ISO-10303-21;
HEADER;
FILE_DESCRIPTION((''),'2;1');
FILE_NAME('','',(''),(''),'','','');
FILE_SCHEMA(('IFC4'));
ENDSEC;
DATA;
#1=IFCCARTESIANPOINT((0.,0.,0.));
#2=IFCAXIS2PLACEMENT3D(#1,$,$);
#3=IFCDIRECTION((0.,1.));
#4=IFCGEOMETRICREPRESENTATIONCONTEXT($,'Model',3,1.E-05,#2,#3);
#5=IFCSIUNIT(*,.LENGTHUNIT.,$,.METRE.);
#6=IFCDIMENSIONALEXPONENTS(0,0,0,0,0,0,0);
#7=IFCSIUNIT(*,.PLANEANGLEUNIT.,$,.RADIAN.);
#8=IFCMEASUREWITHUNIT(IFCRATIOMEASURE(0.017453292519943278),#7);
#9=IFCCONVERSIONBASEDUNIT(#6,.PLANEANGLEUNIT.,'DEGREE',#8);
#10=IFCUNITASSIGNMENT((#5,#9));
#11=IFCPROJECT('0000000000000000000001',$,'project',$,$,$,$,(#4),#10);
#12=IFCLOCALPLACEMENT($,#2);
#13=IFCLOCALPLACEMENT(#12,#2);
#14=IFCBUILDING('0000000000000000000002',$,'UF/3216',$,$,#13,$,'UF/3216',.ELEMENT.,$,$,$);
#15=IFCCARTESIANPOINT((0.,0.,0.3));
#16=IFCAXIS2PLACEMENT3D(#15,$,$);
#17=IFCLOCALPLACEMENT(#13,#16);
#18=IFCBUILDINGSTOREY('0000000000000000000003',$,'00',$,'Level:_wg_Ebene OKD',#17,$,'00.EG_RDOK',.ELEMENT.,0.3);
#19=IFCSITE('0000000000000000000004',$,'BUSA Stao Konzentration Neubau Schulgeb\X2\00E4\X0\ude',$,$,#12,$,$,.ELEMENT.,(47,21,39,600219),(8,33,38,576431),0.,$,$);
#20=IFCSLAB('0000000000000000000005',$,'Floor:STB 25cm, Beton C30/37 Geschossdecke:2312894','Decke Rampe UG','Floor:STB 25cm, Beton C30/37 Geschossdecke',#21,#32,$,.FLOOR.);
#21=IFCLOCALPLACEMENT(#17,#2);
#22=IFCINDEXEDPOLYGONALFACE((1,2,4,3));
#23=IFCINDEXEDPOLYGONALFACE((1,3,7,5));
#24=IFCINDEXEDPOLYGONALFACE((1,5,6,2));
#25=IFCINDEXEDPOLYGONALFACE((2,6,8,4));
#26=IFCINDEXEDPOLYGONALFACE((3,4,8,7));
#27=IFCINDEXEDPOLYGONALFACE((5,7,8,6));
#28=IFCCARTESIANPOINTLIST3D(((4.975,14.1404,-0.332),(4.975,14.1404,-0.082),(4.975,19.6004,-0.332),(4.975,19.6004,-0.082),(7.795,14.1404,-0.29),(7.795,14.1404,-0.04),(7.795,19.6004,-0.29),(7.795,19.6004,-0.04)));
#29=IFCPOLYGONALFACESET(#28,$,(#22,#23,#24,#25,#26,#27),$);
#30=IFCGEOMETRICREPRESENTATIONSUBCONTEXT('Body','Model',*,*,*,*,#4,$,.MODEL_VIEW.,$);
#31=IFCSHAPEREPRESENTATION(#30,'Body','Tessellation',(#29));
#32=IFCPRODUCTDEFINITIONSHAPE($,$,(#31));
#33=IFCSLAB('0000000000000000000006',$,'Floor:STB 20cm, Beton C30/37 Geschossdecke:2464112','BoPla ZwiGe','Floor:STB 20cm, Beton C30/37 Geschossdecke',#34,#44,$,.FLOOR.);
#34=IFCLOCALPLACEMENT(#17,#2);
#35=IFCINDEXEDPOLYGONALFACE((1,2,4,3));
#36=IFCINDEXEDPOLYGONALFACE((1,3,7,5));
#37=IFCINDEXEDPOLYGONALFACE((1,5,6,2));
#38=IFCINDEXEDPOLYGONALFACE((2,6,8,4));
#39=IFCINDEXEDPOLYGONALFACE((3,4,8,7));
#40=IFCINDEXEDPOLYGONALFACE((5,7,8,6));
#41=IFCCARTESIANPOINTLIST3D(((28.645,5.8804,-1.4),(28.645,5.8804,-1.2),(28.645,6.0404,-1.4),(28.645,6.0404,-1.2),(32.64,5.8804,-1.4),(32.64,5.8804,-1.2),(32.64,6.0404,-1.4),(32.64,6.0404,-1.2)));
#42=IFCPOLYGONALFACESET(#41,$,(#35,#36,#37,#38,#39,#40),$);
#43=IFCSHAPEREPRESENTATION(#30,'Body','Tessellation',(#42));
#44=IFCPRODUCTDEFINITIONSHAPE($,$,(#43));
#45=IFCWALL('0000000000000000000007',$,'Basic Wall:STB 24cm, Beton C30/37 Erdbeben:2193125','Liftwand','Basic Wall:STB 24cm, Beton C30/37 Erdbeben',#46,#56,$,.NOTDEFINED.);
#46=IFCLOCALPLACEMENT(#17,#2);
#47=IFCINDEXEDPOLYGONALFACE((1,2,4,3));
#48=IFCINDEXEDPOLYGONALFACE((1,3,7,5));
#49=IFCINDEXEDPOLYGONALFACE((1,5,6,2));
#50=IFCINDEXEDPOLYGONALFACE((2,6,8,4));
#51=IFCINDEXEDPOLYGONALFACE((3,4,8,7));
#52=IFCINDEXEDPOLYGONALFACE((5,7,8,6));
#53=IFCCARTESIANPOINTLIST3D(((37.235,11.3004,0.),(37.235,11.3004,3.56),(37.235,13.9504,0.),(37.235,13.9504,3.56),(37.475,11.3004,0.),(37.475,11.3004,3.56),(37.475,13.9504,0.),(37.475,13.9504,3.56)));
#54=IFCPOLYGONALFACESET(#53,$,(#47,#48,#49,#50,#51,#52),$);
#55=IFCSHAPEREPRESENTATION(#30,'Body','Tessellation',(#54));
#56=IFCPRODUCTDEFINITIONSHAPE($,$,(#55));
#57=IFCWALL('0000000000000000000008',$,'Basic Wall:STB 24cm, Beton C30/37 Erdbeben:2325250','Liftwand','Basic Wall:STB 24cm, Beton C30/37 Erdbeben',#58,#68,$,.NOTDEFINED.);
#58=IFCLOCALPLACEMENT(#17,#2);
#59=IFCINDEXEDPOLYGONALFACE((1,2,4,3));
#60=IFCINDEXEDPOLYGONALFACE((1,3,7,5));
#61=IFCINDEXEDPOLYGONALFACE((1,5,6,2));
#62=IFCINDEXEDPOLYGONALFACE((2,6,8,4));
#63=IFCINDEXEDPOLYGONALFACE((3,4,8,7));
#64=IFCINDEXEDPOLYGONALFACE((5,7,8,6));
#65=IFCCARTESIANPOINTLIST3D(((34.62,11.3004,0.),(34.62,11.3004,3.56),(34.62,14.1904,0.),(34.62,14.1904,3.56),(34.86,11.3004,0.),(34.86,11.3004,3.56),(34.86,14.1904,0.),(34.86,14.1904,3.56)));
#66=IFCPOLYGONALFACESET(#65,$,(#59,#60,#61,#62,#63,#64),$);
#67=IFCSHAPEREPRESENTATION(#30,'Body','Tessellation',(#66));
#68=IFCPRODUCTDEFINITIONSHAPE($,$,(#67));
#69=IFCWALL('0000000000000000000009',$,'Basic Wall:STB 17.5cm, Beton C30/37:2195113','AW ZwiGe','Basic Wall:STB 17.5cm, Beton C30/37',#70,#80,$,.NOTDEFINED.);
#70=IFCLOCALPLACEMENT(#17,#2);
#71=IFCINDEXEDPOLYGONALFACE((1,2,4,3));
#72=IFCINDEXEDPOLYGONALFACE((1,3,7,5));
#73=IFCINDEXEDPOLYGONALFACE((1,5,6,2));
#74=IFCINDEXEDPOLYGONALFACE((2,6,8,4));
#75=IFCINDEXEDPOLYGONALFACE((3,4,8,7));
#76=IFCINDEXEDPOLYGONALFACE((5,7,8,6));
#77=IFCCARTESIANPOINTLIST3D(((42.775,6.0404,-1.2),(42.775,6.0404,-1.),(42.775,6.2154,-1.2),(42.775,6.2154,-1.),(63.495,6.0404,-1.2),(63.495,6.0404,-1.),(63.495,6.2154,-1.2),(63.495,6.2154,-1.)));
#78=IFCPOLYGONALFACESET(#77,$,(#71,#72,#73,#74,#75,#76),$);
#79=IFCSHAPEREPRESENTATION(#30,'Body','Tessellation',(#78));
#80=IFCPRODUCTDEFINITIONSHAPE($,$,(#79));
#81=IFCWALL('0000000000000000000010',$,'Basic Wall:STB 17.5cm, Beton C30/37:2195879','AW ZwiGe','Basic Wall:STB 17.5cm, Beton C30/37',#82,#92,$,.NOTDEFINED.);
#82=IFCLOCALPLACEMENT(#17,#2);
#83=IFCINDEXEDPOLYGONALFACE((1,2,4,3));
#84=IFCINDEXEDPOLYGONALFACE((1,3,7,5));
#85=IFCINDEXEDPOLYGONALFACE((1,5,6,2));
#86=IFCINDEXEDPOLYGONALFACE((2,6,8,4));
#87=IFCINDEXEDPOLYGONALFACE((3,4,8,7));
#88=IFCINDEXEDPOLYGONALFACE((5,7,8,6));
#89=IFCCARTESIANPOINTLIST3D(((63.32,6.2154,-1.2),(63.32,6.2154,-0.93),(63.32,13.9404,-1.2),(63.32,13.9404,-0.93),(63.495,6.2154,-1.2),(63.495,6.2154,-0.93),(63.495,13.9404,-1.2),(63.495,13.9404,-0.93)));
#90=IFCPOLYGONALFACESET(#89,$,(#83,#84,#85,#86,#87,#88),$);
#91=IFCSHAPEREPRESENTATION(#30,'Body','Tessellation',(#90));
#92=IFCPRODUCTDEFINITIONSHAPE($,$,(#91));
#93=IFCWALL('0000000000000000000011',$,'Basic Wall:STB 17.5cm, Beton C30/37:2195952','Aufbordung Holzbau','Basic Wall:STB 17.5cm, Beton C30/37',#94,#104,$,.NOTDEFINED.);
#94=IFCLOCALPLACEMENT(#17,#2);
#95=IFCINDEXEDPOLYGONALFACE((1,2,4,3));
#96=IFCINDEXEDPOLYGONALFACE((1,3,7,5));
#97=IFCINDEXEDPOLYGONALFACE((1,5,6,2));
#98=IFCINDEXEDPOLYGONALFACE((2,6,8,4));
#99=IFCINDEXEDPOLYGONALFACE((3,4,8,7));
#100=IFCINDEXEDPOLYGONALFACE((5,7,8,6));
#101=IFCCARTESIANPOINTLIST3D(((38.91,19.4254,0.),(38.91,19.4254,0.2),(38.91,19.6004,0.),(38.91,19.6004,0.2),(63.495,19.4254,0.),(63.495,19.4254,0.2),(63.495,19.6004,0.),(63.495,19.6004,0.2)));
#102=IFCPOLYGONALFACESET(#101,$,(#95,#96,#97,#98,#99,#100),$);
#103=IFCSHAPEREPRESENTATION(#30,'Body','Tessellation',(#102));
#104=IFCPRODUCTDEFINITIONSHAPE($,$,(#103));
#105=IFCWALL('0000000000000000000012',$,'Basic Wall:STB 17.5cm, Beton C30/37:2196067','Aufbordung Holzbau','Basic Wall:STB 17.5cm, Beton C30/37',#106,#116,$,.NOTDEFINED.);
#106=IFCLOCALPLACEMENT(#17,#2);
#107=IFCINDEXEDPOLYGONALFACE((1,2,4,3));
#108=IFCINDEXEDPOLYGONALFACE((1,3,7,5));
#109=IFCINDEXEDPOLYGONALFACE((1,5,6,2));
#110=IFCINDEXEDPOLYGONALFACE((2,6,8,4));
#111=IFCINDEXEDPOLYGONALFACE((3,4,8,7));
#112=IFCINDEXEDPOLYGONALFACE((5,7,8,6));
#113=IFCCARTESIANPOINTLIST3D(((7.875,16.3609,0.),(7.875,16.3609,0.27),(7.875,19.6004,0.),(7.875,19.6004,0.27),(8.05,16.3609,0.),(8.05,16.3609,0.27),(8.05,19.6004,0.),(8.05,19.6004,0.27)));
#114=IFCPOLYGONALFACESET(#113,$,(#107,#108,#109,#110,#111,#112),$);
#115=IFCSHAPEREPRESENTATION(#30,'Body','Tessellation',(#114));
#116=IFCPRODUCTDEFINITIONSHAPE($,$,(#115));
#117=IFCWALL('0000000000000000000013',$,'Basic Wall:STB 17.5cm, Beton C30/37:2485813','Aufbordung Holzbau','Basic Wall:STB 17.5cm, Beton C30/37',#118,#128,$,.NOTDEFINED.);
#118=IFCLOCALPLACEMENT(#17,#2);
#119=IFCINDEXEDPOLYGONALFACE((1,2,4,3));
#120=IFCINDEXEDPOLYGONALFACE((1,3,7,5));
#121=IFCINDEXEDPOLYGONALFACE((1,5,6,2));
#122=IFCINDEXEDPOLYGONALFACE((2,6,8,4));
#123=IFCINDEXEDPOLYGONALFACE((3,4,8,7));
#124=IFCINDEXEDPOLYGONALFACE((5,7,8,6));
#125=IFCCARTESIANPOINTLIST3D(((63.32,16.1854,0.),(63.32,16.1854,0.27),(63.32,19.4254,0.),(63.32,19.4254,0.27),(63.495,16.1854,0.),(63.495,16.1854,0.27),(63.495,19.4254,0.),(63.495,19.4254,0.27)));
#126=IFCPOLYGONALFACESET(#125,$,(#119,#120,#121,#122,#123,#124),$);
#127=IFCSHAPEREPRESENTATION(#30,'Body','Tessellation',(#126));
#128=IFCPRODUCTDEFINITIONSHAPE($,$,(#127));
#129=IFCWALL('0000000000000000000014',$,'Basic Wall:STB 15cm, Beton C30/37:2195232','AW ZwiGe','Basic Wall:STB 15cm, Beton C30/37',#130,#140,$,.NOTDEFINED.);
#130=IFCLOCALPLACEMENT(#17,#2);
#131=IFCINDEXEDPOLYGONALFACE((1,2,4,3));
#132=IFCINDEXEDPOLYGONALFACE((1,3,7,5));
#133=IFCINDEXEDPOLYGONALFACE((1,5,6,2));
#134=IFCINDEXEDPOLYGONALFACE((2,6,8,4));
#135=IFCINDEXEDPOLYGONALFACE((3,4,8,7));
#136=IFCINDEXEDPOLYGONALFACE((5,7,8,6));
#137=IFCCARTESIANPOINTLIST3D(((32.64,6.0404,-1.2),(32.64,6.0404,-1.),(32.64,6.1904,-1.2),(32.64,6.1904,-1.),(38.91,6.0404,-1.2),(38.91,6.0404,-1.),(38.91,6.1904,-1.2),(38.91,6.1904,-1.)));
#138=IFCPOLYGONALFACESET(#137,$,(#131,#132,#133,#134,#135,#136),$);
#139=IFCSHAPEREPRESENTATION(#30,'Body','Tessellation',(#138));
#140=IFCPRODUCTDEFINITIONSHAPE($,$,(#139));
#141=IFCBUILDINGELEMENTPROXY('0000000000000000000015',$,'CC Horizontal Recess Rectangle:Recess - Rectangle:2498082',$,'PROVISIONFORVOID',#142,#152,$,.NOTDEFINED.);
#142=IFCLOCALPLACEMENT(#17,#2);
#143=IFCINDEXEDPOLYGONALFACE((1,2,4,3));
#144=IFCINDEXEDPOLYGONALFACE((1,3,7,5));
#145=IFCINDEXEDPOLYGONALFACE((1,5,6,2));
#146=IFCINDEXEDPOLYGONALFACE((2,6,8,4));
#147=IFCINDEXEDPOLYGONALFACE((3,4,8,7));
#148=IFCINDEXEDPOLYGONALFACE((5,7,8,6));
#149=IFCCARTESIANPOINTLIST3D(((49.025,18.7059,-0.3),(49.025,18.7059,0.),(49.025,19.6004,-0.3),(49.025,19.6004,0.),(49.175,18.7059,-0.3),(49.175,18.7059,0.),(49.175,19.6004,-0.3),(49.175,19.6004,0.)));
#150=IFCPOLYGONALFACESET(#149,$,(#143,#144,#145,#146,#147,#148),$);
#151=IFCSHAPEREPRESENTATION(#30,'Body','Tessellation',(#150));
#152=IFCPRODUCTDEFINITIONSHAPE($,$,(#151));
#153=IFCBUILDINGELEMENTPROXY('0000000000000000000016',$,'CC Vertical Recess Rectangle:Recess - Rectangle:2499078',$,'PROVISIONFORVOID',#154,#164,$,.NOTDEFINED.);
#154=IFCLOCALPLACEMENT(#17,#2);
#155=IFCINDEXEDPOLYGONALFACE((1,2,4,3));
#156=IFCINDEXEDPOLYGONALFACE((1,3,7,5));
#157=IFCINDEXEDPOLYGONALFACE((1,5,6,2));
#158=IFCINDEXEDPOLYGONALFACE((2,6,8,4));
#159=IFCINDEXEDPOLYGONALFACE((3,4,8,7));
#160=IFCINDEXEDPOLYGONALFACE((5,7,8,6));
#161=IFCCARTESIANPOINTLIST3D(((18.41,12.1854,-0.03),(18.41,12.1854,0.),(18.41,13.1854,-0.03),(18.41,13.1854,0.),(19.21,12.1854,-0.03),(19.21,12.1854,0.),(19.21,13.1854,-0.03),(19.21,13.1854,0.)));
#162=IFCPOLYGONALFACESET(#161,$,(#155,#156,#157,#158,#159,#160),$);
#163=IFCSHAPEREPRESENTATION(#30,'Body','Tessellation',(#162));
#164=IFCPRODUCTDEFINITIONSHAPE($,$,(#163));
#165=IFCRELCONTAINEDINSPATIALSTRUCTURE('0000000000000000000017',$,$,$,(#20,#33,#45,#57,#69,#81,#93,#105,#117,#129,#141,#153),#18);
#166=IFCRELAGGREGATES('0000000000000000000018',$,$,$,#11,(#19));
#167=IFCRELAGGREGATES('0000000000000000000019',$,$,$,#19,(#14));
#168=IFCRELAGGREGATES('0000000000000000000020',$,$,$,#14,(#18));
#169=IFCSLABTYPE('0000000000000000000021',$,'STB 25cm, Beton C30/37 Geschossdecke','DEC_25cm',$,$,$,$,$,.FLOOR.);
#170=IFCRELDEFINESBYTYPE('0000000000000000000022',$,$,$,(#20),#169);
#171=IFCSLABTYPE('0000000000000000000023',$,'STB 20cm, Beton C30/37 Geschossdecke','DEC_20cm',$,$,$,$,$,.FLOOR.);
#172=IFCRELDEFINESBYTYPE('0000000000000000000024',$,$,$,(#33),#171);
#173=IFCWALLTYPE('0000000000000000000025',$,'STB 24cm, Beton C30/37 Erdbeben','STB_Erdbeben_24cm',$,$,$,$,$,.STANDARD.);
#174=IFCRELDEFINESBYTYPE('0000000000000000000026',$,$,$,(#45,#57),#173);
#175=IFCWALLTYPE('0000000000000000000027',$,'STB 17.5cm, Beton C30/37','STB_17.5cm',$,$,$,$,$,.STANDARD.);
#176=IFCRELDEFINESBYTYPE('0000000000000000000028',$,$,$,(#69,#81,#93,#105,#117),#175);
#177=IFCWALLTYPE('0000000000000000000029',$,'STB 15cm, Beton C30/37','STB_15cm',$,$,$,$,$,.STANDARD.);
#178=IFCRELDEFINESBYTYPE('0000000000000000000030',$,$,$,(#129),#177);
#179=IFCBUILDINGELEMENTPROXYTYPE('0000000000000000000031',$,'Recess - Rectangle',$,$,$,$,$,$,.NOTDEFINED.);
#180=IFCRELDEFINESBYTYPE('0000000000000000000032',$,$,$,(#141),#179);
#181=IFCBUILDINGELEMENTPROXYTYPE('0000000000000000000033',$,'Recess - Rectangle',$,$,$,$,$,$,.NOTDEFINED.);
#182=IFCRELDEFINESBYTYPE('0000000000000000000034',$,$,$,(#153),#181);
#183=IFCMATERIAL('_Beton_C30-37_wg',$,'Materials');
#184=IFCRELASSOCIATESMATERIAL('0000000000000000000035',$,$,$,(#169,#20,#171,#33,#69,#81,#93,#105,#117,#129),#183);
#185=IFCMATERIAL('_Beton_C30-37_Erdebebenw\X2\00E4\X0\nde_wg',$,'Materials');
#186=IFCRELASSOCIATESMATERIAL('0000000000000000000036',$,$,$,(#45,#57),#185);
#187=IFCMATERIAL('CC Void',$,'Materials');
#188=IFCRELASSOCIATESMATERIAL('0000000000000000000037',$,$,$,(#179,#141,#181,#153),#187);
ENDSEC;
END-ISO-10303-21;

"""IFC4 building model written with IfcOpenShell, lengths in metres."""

from ifc_helpers import new_model, entity, si_unit, converted_unit, direction, frame, frame_2d, origin, place, context, subcontext, project, spatial, indexed_curve, rectangle, outline, extrude, source, transform, mapped, material, type_object, type_shapes, element, save


model = new_model("IFC4")

# Units and contexts
model_context = context("Model", 3, precision=1e-05, world=origin(), true_north=direction((0.0, 1.0)))
body_context = subcontext(model_context, "Body", "Model", "MODEL_VIEW")
ifc_project = project(units=[si_unit("LENGTHUNIT", "METRE"), converted_unit("PLANEANGLEUNIT", "DEGREE", entity("IfcRatioMeasure", 0.017453292519943278), si_unit("PLANEANGLEUNIT", "RADIAN"), dimensions=[0, 0, 0, 0, 0, 0, 0])], contexts=[model_context])

# Site, building, storey
site_placement = place(None, origin())
site = spatial("IfcSite", under=ifc_project, at=site_placement, Name="BUSA Stao Konzentration Neubau Schulgebäude", CompositionType="ELEMENT", RefLatitude=(47, 21, 39, 600219), RefLongitude=(8, 33, 38, 576431), RefElevation=0.0)
building_placement = place(site_placement, origin())
building = spatial("IfcBuilding", under=site, at=building_placement, Name="UF/3216", LongName="UF/3216", CompositionType="ELEMENT")
storey_placement = place(building_placement, frame((0.0, 0.0, 0.3)))
storey = spatial("IfcBuildingStorey", under=building, at=storey_placement, Name="00", ObjectType="Level:_wg_Ebene OKD", LongName="00.EG_RDOK", CompositionType="ELEMENT", Elevation=0.3)

# Slabs
ifc_material_1 = material(Name="_Beton_C30-37_wg", Category="Materials")
slab_type_1 = type_object("IfcSlabType", Name="STB 25cm, Beton C30/37 Geschossdecke", Description="DEC_25cm", PredefinedType="FLOOR", material=ifc_material_1)
slab_1_placement = place(storey_placement, frame((4.975, 14.1404, -0.332)))
element("IfcSlab", 1, at=slab_1_placement, inside=storey, type_object=slab_type_1, material=ifc_material_1, Name="Floor:STB 25cm, Beton C30/37 Geschossdecke:2312894", Description="Decke Rampe UG", ObjectType="Floor:STB 25cm, Beton C30/37 Geschossdecke", PredefinedType="FLOOR", context=body_context, shape_type="SweptSolid", body=[
    extrude(rectangle(XDim=5.46, YDim=2.8203, at=frame_2d((-1.4102, 0.0), x_axis=(0.0, -1.0))), frame((2.82, 2.73, 0.292), z_axis=(-0.014892, 0.0, 0.999889), x_axis=(0.999889, 0.0, 0.014892)), (-0.014892, 0.0, -0.999889), 0.25),
])
slab_type_2 = type_object("IfcSlabType", Name="STB 20cm, Beton C30/37 Geschossdecke", Description="DEC_20cm", PredefinedType="FLOOR", material=ifc_material_1)
slab_2_placement = place(storey_placement, frame((28.645, 5.8804, -1.4)))
element("IfcSlab", 2, at=slab_2_placement, inside=storey, type_object=slab_type_2, material=ifc_material_1, Name="Floor:STB 20cm, Beton C30/37 Geschossdecke:2464112", Description="BoPla ZwiGe", ObjectType="Floor:STB 20cm, Beton C30/37 Geschossdecke", PredefinedType="FLOOR", context=body_context, shape_type="SweptSolid", body=[
    extrude(rectangle(XDim=3.995, YDim=0.16, at=frame_2d((5.0675, 0.0), x_axis=(-1.0, 0.0))), frame((7.065, 0.08, 0.2), z_axis=(0.0, 0.0, -1.0), x_axis=(-1.0, 0.0, 0.0)), (0.0, 0.0, 1.0), 0.2),
])

# Walls
ifc_material_2 = material(Name="_Beton_C30-37_Erdebebenwände_wg", Category="Materials")
wall_type_1 = type_object("IfcWallType", Name="STB 24cm, Beton C30/37 Erdbeben", Description="STB_Erdbeben_24cm", PredefinedType="STANDARD")
wall_1_placement = place(storey_placement, frame((37.355, 13.9504, 0.0), z_axis=(0.0, 0.0, 1.0), x_axis=(0.0, -1.0, 0.0)))
element("IfcWall", 3, at=wall_1_placement, inside=storey, type_object=wall_type_1, material=ifc_material_2, Name="Basic Wall:STB 24cm, Beton C30/37 Erdbeben:2193125", Description="Liftwand", ObjectType="Basic Wall:STB 24cm, Beton C30/37 Erdbeben", PredefinedType="NOTDEFINED", context=body_context, shape_type="SweptSolid", body=[
    extrude(outline(indexed_curve([(2.65, 0.12), (0.0, 0.12), (0.0, -0.12), (2.65, -0.12), (2.65, 0.12)], self_intersect=False)), origin(), (0.0, 0.0, 1.0), 3.56),
])
wall_2_placement = place(storey_placement, frame((34.74, 11.3004, 0.0), z_axis=(0.0, 0.0, 1.0), x_axis=(0.0, 1.0, 0.0)))
element("IfcWall", 4, at=wall_2_placement, inside=storey, type_object=wall_type_1, material=ifc_material_2, Name="Basic Wall:STB 24cm, Beton C30/37 Erdbeben:2325250", Description="Liftwand", ObjectType="Basic Wall:STB 24cm, Beton C30/37 Erdbeben", PredefinedType="NOTDEFINED", context=body_context, shape_type="SweptSolid", body=[
    extrude(outline(indexed_curve([(2.89, 0.12), (0.0, 0.12), (0.0, -0.12), (2.89, -0.12), (2.89, 0.12)], self_intersect=False)), origin(), (0.0, 0.0, 1.0), 3.56),
])
wall_type_2 = type_object("IfcWallType", Name="STB 17.5cm, Beton C30/37", Description="STB_17.5cm", PredefinedType="STANDARD")
wall_3_placement = place(storey_placement, frame((63.495, 6.1279, -1.2), z_axis=(0.0, 0.0, 1.0), x_axis=(-1.0, 0.0, 0.0)))
element("IfcWall", 5, at=wall_3_placement, inside=storey, type_object=wall_type_2, material=ifc_material_1, Name="Basic Wall:STB 17.5cm, Beton C30/37:2195113", Description="AW ZwiGe", ObjectType="Basic Wall:STB 17.5cm, Beton C30/37", PredefinedType="NOTDEFINED", context=body_context, shape_type="SweptSolid", body=[
    extrude(outline(indexed_curve([(20.72, 0.0875), (0.0, 0.0875), (0.0, -0.0875), (20.72, -0.0875), (20.72, 0.0875)], self_intersect=False)), origin(), (0.0, 0.0, 1.0), 0.2),
])
wall_4_placement = place(storey_placement, frame((63.4075, 6.2154, -1.2), z_axis=(0.0, 0.0, 1.0), x_axis=(0.0, 1.0, 0.0)))
element("IfcWall", 6, at=wall_4_placement, inside=storey, type_object=wall_type_2, material=ifc_material_1, Name="Basic Wall:STB 17.5cm, Beton C30/37:2195879", Description="AW ZwiGe", ObjectType="Basic Wall:STB 17.5cm, Beton C30/37", PredefinedType="NOTDEFINED", context=body_context, shape_type="SweptSolid", body=[
    extrude(outline(indexed_curve([(7.725, 0.0875), (0.0, 0.0875), (0.0, -0.0875), (7.725, -0.0875), (7.725, 0.0875)], self_intersect=False)), origin(), (0.0, 0.0, 1.0), 0.27),
])
wall_5_placement = place(storey_placement, frame((63.495, 19.5129, 0.0), z_axis=(0.0, 0.0, 1.0), x_axis=(-1.0, 0.0, 0.0)))
element("IfcWall", 7, at=wall_5_placement, inside=storey, type_object=wall_type_2, material=ifc_material_1, Name="Basic Wall:STB 17.5cm, Beton C30/37:2195952", Description="Aufbordung Holzbau", ObjectType="Basic Wall:STB 17.5cm, Beton C30/37", PredefinedType="NOTDEFINED", context=body_context, shape_type="SweptSolid", body=[
    extrude(outline(indexed_curve([(24.585, 0.0875), (0.0, 0.0875), (0.0, -0.0875), (24.585, -0.0875), (24.585, 0.0875)], self_intersect=False)), origin(), (0.0, 0.0, 1.0), 0.2),
])
wall_6_placement = place(storey_placement, frame((7.9625, 19.6004, 0.0), z_axis=(0.0, 0.0, 1.0), x_axis=(0.0, -1.0, 0.0)))
element("IfcWall", 8, at=wall_6_placement, inside=storey, type_object=wall_type_2, material=ifc_material_1, Name="Basic Wall:STB 17.5cm, Beton C30/37:2196067", Description="Aufbordung Holzbau", ObjectType="Basic Wall:STB 17.5cm, Beton C30/37", PredefinedType="NOTDEFINED", context=body_context, shape_type="SweptSolid", body=[
    extrude(outline(indexed_curve([(3.2395, 0.0875), (0.0, 0.0875), (0.0, -0.0875), (3.2395, -0.0875), (3.2395, 0.0875)], self_intersect=False)), origin(), (0.0, 0.0, 1.0), 0.27),
])
wall_7_placement = place(storey_placement, frame((63.4075, 19.4254, 0.0), z_axis=(0.0, 0.0, 1.0), x_axis=(0.0, -1.0, 0.0)))
element("IfcWall", 9, at=wall_7_placement, inside=storey, type_object=wall_type_2, material=ifc_material_1, Name="Basic Wall:STB 17.5cm, Beton C30/37:2485813", Description="Aufbordung Holzbau", ObjectType="Basic Wall:STB 17.5cm, Beton C30/37", PredefinedType="NOTDEFINED", context=body_context, shape_type="SweptSolid", body=[
    extrude(outline(indexed_curve([(3.24, 0.0875), (0.0, 0.0875), (0.0, -0.0875), (3.24, -0.0875), (3.24, 0.0875)], self_intersect=False)), origin(), (0.0, 0.0, 1.0), 0.27),
])
wall_type_3 = type_object("IfcWallType", Name="STB 15cm, Beton C30/37", Description="STB_15cm", PredefinedType="STANDARD")
wall_8_placement = place(storey_placement, frame((38.91, 6.1154, -1.2), z_axis=(0.0, 0.0, 1.0), x_axis=(-1.0, 0.0, 0.0)))
element("IfcWall", 10, at=wall_8_placement, inside=storey, type_object=wall_type_3, material=ifc_material_1, Name="Basic Wall:STB 15cm, Beton C30/37:2195232", Description="AW ZwiGe", ObjectType="Basic Wall:STB 15cm, Beton C30/37", PredefinedType="NOTDEFINED", context=body_context, shape_type="SweptSolid", body=[
    extrude(outline(indexed_curve([(6.27, 0.075), (0.0, 0.075), (0.0, -0.075), (6.27, -0.075), (6.27, 0.075)], self_intersect=False)), origin(), (0.0, 0.0, 1.0), 0.2),
])

# Building element proxies
ifc_material_3 = material(Name="CC Void", Category="Materials")
building_element_proxy_type_1 = type_object("IfcBuildingElementProxyType", Name="Recess - Rectangle", PredefinedType="NOTDEFINED", material=ifc_material_3)
shared_shape_1 = source(origin(), body_context, "Body", "SweptSolid", [
    extrude(outline(indexed_curve([(-0.4472, -0.075), (0.4472, -0.075), (0.4472, 0.075), (-0.4472, 0.075), (-0.4472, -0.075)], self_intersect=False)), frame((0.0, 0.0, 0.0), z_axis=(0.0, 0.0, 1.0), x_axis=(0.0, -1.0, 0.0)), (0.0, 0.0, 1.0), 0.3),
])
type_shapes(building_element_proxy_type_1, [shared_shape_1])
proxy_1_placement = place(storey_placement, frame((49.1, 19.1532, -0.3)))
element("IfcBuildingElementProxy", 11, at=proxy_1_placement, inside=storey, type_object=building_element_proxy_type_1, material=ifc_material_3, Name="CC Horizontal Recess Rectangle:Recess - Rectangle:2498082", ObjectType="PROVISIONFORVOID", PredefinedType="NOTDEFINED", context=body_context, shape_type="MappedRepresentation", body=[
    mapped(shared_shape_1, transform((0.0, 0.0, 0.0), scale=1.0)),
])
building_element_proxy_type_2 = type_object("IfcBuildingElementProxyType", Name="Recess - Rectangle", PredefinedType="NOTDEFINED", material=ifc_material_3)
shared_shape_2 = source(origin(), body_context, "Body", "SweptSolid", [
    extrude(outline(indexed_curve([(-0.4, -0.5), (0.4, -0.5), (0.4, 0.5), (-0.4, 0.5), (-0.4, -0.5)], self_intersect=False)), frame((0.0, 0.0, 0.27), z_axis=(0.0, 0.0, 1.0), x_axis=(0.0, 1.0, 0.0)), (0.0, 0.0, 1.0), 0.03),
])
type_shapes(building_element_proxy_type_2, [shared_shape_2])
proxy_2_placement = place(storey_placement, frame((18.81, 12.6854, -0.3), z_axis=(0.0, 0.0, 1.0), x_axis=(0.0, -1.0, 0.0)))
element("IfcBuildingElementProxy", 12, at=proxy_2_placement, inside=storey, type_object=building_element_proxy_type_2, material=ifc_material_3, Name="CC Vertical Recess Rectangle:Recess - Rectangle:2499078", ObjectType="PROVISIONFORVOID", PredefinedType="NOTDEFINED", context=body_context, shape_type="MappedRepresentation", body=[
    mapped(shared_shape_2, transform((0.0, 0.0, 0.0), scale=1.0)),
])

save(model, "model.ifc")
